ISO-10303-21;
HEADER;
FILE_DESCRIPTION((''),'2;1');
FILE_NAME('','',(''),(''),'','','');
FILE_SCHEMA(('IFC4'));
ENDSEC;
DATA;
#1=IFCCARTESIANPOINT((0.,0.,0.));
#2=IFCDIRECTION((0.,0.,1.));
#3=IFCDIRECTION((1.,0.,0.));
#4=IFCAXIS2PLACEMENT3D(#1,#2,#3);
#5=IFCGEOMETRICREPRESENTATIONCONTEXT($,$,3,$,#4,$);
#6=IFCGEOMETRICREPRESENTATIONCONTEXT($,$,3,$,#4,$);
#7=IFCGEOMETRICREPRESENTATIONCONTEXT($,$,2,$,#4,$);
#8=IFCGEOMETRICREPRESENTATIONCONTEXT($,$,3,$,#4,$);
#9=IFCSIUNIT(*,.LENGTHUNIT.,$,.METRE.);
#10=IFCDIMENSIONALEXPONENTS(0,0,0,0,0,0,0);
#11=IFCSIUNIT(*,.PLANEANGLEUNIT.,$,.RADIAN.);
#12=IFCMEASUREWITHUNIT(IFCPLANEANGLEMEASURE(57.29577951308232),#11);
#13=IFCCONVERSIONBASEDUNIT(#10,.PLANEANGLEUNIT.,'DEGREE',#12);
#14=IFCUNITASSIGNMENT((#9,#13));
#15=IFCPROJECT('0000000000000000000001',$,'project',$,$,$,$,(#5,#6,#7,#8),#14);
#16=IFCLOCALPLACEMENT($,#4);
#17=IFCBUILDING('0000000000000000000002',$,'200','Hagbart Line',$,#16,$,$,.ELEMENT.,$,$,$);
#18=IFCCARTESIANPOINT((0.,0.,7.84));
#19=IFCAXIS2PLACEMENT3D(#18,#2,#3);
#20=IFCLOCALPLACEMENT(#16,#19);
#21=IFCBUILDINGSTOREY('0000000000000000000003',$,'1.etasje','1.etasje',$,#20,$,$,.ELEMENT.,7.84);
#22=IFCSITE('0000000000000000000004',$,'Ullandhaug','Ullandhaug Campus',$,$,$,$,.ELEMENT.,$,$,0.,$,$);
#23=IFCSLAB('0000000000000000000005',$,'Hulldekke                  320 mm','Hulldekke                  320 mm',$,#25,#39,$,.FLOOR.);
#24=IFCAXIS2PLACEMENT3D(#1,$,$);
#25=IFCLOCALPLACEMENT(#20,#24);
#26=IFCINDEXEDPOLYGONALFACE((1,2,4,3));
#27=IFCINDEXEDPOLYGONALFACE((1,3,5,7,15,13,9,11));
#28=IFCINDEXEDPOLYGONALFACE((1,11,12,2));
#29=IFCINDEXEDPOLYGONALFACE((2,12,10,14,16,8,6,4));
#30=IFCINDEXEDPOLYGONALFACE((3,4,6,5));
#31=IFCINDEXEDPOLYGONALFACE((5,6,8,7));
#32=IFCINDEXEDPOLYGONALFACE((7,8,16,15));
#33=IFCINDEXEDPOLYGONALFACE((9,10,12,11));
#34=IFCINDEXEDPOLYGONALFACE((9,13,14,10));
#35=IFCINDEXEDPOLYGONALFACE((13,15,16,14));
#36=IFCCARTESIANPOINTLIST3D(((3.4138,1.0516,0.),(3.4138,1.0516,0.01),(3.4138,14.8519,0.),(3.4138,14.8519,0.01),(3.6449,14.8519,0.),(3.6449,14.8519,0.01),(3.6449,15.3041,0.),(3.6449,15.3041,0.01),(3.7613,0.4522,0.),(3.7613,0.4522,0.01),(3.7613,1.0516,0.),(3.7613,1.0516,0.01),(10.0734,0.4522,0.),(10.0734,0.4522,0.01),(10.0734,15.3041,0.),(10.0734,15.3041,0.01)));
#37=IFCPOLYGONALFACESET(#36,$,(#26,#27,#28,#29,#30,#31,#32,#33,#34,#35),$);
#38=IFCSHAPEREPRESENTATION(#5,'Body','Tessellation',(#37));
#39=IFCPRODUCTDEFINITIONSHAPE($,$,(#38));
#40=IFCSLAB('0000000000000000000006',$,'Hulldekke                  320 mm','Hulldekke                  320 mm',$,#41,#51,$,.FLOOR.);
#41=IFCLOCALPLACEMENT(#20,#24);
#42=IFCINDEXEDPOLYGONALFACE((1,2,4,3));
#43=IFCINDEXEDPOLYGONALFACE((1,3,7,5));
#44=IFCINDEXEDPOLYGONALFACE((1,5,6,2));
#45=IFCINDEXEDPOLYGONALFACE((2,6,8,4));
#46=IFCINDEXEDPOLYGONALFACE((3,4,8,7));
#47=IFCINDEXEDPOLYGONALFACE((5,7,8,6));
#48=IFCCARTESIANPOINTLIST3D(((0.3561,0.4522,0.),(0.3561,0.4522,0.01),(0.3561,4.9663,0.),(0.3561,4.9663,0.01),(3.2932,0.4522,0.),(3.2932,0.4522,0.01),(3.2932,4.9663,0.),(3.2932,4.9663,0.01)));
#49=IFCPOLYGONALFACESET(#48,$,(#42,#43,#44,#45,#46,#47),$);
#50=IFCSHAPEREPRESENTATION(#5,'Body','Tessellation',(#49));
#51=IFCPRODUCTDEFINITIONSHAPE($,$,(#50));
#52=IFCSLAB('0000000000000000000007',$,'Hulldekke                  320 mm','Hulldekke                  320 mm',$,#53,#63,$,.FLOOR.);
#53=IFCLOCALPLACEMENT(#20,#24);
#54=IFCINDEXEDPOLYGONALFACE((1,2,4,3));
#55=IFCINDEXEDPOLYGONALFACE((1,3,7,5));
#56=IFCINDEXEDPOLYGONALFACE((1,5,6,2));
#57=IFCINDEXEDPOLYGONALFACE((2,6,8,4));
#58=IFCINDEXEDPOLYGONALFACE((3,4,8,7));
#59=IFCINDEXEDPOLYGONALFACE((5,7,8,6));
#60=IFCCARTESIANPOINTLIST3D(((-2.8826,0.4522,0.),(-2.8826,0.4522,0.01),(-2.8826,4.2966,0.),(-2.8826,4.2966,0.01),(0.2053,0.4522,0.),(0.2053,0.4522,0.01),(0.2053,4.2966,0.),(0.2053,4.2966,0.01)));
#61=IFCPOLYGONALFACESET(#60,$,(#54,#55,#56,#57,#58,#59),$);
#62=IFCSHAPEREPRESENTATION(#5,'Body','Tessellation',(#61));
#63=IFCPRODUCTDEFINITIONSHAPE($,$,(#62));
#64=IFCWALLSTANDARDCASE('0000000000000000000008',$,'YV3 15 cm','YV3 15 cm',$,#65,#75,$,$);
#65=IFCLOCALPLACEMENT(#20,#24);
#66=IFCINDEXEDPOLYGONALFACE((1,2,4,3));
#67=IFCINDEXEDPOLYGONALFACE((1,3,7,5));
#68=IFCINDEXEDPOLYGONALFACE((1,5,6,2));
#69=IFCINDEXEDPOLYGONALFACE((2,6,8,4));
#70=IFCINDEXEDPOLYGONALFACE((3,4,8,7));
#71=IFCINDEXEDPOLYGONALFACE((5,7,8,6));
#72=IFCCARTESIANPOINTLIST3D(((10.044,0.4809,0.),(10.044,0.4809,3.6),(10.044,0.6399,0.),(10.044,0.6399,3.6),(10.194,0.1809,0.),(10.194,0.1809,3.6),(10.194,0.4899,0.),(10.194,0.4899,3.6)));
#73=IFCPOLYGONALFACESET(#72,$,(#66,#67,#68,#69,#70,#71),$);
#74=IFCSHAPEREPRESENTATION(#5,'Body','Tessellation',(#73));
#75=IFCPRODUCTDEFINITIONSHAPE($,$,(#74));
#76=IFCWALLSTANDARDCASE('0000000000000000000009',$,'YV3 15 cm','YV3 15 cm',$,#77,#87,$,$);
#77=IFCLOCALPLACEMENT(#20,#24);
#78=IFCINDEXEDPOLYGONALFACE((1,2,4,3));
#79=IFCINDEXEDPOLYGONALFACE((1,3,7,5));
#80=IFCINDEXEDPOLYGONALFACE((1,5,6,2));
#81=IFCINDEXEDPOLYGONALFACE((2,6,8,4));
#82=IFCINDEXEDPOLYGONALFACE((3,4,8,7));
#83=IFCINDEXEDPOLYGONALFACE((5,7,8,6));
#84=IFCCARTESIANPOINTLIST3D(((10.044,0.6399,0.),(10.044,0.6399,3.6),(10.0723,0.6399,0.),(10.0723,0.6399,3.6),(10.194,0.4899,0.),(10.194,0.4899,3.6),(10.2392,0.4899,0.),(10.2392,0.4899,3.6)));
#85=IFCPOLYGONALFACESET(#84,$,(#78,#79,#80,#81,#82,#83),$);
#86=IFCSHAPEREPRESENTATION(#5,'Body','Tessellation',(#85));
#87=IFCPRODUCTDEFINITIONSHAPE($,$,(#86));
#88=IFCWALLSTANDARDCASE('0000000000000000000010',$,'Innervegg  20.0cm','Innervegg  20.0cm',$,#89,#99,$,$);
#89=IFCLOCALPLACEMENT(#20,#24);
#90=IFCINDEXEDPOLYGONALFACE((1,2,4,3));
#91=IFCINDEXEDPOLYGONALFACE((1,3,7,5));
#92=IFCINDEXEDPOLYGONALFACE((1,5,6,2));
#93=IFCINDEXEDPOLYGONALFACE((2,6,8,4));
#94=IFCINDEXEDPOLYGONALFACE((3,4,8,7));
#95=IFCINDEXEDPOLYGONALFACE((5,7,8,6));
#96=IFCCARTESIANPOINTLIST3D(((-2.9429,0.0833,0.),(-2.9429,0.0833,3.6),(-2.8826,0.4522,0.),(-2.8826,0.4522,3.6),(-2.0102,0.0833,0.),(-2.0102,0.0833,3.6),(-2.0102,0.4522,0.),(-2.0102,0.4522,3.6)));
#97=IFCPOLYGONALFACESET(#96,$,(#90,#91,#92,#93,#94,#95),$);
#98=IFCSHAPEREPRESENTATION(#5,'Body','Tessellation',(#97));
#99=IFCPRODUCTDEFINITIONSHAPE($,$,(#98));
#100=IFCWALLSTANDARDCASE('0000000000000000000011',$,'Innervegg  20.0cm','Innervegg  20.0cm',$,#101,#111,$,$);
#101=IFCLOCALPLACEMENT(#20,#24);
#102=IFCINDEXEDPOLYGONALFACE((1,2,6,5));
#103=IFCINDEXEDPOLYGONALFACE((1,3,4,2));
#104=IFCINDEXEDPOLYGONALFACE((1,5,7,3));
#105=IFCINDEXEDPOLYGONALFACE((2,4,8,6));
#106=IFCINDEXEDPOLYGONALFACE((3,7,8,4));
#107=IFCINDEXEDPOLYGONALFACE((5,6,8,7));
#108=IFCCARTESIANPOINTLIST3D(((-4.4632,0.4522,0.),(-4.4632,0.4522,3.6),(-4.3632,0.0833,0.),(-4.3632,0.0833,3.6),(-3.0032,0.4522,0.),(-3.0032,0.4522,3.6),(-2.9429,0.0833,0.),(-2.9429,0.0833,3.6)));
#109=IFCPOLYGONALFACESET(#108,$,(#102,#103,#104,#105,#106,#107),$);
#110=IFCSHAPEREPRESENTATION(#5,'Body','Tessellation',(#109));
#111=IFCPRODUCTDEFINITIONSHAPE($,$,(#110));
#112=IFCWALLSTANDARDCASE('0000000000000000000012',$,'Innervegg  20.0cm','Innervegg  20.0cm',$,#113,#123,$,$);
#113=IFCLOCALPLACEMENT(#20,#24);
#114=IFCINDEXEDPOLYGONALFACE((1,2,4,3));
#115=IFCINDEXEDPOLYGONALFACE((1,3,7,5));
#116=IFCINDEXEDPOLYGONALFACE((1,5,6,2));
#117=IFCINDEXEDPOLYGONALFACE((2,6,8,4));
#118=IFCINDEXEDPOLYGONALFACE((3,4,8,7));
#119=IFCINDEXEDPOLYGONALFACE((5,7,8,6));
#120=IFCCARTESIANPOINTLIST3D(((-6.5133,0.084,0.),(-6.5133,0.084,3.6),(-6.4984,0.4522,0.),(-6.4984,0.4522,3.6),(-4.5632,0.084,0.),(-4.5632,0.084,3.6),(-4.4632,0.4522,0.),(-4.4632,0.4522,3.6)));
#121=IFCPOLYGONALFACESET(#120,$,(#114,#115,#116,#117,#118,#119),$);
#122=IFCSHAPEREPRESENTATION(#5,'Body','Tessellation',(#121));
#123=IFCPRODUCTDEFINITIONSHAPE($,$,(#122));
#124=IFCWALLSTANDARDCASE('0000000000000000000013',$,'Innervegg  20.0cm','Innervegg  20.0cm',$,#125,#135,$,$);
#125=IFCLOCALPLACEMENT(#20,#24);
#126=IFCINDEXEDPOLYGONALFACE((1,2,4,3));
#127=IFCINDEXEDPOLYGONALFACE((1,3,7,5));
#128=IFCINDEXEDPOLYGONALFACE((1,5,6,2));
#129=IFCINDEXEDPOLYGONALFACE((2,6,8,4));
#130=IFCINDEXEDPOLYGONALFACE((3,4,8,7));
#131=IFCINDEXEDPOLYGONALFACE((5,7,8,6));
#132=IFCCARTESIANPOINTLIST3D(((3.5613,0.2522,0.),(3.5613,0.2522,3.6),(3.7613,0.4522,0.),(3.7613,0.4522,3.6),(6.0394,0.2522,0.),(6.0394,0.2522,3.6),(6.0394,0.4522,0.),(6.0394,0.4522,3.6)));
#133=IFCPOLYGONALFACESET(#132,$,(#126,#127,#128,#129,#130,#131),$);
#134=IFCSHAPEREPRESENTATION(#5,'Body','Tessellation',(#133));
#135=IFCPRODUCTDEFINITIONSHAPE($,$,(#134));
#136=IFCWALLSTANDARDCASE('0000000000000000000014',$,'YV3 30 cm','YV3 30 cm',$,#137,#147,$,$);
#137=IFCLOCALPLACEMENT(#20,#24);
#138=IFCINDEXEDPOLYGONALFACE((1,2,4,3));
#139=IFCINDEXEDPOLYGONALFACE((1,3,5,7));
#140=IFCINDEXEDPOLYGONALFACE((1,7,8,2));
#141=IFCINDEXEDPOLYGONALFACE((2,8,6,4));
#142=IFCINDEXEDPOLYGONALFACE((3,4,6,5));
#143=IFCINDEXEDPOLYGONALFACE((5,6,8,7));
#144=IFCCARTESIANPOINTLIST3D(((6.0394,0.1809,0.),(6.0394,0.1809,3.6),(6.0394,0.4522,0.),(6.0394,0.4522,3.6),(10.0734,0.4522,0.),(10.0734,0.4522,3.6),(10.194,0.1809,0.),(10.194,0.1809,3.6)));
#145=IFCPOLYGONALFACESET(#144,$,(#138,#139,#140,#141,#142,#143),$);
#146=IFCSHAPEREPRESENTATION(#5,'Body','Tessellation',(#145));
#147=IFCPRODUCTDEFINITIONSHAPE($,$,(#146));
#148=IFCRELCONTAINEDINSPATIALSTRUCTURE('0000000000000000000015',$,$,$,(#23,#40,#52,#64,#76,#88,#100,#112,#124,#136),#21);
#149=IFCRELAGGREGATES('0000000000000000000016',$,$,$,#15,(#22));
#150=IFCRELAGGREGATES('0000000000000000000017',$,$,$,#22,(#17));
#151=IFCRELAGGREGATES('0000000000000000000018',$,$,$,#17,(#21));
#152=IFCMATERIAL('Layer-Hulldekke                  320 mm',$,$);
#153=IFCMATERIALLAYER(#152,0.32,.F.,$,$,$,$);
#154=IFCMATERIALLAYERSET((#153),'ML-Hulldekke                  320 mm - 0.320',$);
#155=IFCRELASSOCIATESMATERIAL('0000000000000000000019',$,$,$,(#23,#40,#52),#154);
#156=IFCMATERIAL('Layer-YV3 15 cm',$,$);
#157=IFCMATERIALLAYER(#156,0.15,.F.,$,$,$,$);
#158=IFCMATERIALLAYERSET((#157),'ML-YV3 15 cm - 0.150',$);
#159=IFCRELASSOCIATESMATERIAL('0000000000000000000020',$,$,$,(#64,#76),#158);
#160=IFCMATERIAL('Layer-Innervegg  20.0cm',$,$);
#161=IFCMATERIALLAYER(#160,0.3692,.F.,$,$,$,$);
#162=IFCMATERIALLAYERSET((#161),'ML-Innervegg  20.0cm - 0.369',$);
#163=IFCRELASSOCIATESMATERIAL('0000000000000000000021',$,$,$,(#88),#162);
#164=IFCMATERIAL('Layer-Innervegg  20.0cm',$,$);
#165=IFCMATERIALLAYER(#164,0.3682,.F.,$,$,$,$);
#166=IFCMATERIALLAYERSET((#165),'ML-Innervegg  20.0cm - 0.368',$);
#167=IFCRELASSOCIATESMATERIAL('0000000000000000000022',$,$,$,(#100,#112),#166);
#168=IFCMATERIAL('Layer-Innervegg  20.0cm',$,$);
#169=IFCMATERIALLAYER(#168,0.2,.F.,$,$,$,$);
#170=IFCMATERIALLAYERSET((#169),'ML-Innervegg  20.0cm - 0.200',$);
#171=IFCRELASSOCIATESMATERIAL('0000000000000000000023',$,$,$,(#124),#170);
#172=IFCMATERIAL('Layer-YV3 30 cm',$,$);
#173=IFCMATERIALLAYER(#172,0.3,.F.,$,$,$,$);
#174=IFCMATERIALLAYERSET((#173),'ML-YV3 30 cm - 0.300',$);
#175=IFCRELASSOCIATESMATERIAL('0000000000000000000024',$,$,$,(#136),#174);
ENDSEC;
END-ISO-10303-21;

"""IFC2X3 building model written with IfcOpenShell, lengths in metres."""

from ifc_helpers import new_model, entity, si_unit, converted_unit, frame, origin_with_axes, place, context, project, spatial, polyline, outline, extrude, material, layer, layer_set, layer_usage, element, save


model = new_model("IFC2X3")

# Units and contexts
context_of_model_1 = context(None, 3, world=origin_with_axes())
context_of_model_2 = context(None, 3, world=origin_with_axes())
context_of_model_3 = context(None, 2, world=origin_with_axes())
context_of_model_4 = context(None, 3, world=origin_with_axes())
ifc_project = project(units=[si_unit("LENGTHUNIT", "METRE"), converted_unit("PLANEANGLEUNIT", "DEGREE", entity("IfcPlaneAngleMeasure", 57.29577951308232), si_unit("PLANEANGLEUNIT", "RADIAN"), dimensions=[0, 0, 0, 0, 0, 0, 0])], contexts=[context_of_model_1, context_of_model_2, context_of_model_3, context_of_model_4])

# Site, building, storey
site = spatial("IfcSite", under=ifc_project, Name="Ullandhaug", Description="Ullandhaug Campus", CompositionType="ELEMENT", RefElevation=0.0)
building_placement = place(None, origin_with_axes())
building = spatial("IfcBuilding", under=site, at=building_placement, Name="200", Description="Hagbart Line", CompositionType="ELEMENT")
storey_placement = place(building_placement, frame((0.0, 0.0, 7.84), z_axis=(0.0, 0.0, 1.0), x_axis=(1.0, 0.0, 0.0)))
storey = spatial("IfcBuildingStorey", under=building, at=storey_placement, Name="1.etasje", Description="1.etasje", CompositionType="ELEMENT", Elevation=7.84)

# Slabs
ifc_material_1 = material(Name="Layer-Hulldekke                  320 mm")
ifc_layer_1 = layer(ifc_material_1, 0.32, ventilated=False)
ifc_layer_set_1 = layer_set([ifc_layer_1], Name="ML-Hulldekke                  320 mm - 0.320")
ifc_layer_usage_1 = layer_usage(ifc_layer_set_1, "AXIS2", "POSITIVE", 0.0)
slab_1_placement = place(storey_placement, frame((3.7613, 0.4522, 0.0), z_axis=(0.0, 0.0, 1.0), x_axis=(1.0, 0.0, 0.0)))
element("IfcSlab", 1, at=slab_1_placement, inside=storey, material=ifc_layer_usage_1, Name="Hulldekke                  320 mm", Description="Hulldekke                  320 mm", PredefinedType="FLOOR", context=context_of_model_1, shape_type="SweptSolid", body=[
    extrude(outline(polyline([(0.0, 0.0), (6.3121, 0.0), (6.3121, 14.8519), (-0.1164, 14.8519), (-0.1164, 14.3996), (-0.3475, 14.3996), (-0.3475, 0.5994), (0.0, 0.5994), (0.0, 0.0)])), origin_with_axes(), (0.0, 0.0, 1.0), 0.01),
])
slab_2_placement = place(storey_placement, frame((0.3561, 0.4522, 0.0), z_axis=(0.0, 0.0, 1.0), x_axis=(1.0, 0.0, 0.0)))
element("IfcSlab", 2, at=slab_2_placement, inside=storey, material=ifc_layer_usage_1, Name="Hulldekke                  320 mm", Description="Hulldekke                  320 mm", PredefinedType="FLOOR", context=context_of_model_1, shape_type="SweptSolid", body=[
    extrude(outline(polyline([(0.0, 0.0), (2.9371, 0.0), (2.9371, 4.5141), (0.0, 4.5141), (0.0, 0.0)])), origin_with_axes(), (0.0, 0.0, 1.0), 0.01),
])
slab_3_placement = place(storey_placement, frame((-2.8826, 0.4522, 0.0), z_axis=(0.0, 0.0, 1.0), x_axis=(1.0, 0.0, 0.0)))
element("IfcSlab", 3, at=slab_3_placement, inside=storey, material=ifc_layer_usage_1, Name="Hulldekke                  320 mm", Description="Hulldekke                  320 mm", PredefinedType="FLOOR", context=context_of_model_1, shape_type="SweptSolid", body=[
    extrude(outline(polyline([(0.0, 0.0), (3.0879, 0.0), (3.0879, 3.8444), (0.0, 3.8444), (0.0, 0.0)])), origin_with_axes(), (0.0, 0.0, 1.0), 0.01),
])

# Walls
ifc_material_2 = material(Name="Layer-YV3 15 cm")
ifc_layer_2 = layer(ifc_material_2, 0.15, ventilated=False)
ifc_layer_set_2 = layer_set([ifc_layer_2], Name="ML-YV3 15 cm - 0.150")
ifc_layer_usage_2 = layer_usage(ifc_layer_set_2, "AXIS2", "POSITIVE", 0.0)
wall_1_placement = place(storey_placement, frame((10.194, 0.1809, 0.0), z_axis=(0.0, 0.0, 1.0), x_axis=(0.0, 1.0, 0.0)))
element("IfcWallStandardCase", 4, at=wall_1_placement, inside=storey, material=ifc_layer_usage_2, Name="YV3 15 cm", Description="YV3 15 cm", context=context_of_model_1, shape_type="SweptSolid", body=[
    extrude(outline(polyline([(0.0, 0.0), (0.309, 0.0), (0.459, 0.15), (0.3, 0.15), (0.0, 0.0)])), frame((0.0, 0.0, 0.0), z_axis=(0.0, 0.0, 1.0), x_axis=(1.0, 0.0, 0.0)), (0.0, 0.0, 1.0), 3.6),
])
wall_2_placement = place(storey_placement, frame((10.194, 0.4899, 0.0), z_axis=(0.0, 0.0, 1.0), x_axis=(1.0, 0.0, 0.0)))
element("IfcWallStandardCase", 5, at=wall_2_placement, inside=storey, material=ifc_layer_usage_2, Name="YV3 15 cm", Description="YV3 15 cm", context=context_of_model_1, shape_type="SweptSolid", body=[
    extrude(outline(polyline([(0.0, 0.0), (0.0452, 0.0), (-0.1218, 0.15), (-0.15, 0.15), (0.0, 0.0)])), origin_with_axes(), (0.0, 0.0, 1.0), 3.6),
])
ifc_material_3 = material(Name="Layer-Innervegg  20.0cm")
ifc_layer_3 = layer(ifc_material_3, 0.3692, ventilated=False)
ifc_layer_set_3 = layer_set([ifc_layer_3], Name="ML-Innervegg  20.0cm - 0.369")
ifc_layer_usage_3 = layer_usage(ifc_layer_set_3, "AXIS2", "POSITIVE", 0.0)
wall_3_placement = place(storey_placement, frame((-2.0102, 0.4522, 0.0), z_axis=(0.0, 0.0, 1.0), x_axis=(-1.0, 0.0, 0.0)))
element("IfcWallStandardCase", 6, at=wall_3_placement, inside=storey, material=ifc_layer_usage_3, Name="Innervegg  20.0cm", Description="Innervegg  20.0cm", context=context_of_model_1, shape_type="SweptSolid", body=[
    extrude(outline(polyline([(0.0, 0.0), (0.8724, 0.0), (0.9327, 0.3689), (0.0, 0.3689), (0.0, 0.0)])), frame((0.0, 0.0, 0.0), z_axis=(0.0, 0.0, 1.0), x_axis=(1.0, 0.0, 0.0)), (0.0, 0.0, 1.0), 3.6),
])
ifc_material_4 = material(Name="Layer-Innervegg  20.0cm")
ifc_layer_4 = layer(ifc_material_4, 0.3682, ventilated=False)
ifc_layer_set_4 = layer_set([ifc_layer_4], Name="ML-Innervegg  20.0cm - 0.368")
ifc_layer_usage_4 = layer_usage(ifc_layer_set_4, "AXIS2", "POSITIVE", 0.0)
wall_4_placement = place(storey_placement, frame((-3.0032, 0.4522, 0.0), z_axis=(0.0, 0.0, 1.0), x_axis=(-1.0, 0.0, 0.0)))
element("IfcWallStandardCase", 7, at=wall_4_placement, inside=storey, material=ifc_layer_usage_4, Name="Innervegg  20.0cm", Description="Innervegg  20.0cm", context=context_of_model_1, shape_type="SweptSolid", body=[
    extrude(outline(polyline([(0.0, 0.0), (1.46, 0.0), (1.36, 0.3689), (-0.0603, 0.3689), (0.0, 0.0)])), frame((0.0, 0.0, 0.0), z_axis=(0.0, 0.0, 1.0), x_axis=(1.0, 0.0, 0.0)), (0.0, 0.0, 1.0), 3.6),
])
wall_5_placement = place(storey_placement, frame((-4.4632, 0.4522, 0.0), z_axis=(0.0, 0.0, 1.0), x_axis=(-1.0, 0.0, 0.0)))
element("IfcWallStandardCase", 8, at=wall_5_placement, inside=storey, material=ifc_layer_usage_4, Name="Innervegg  20.0cm", Description="Innervegg  20.0cm", context=context_of_model_1, shape_type="SweptSolid", body=[
    extrude(outline(polyline([(0.0, 0.0), (2.0352, 0.0), (2.0501, 0.3682), (0.1, 0.3682), (0.0, 0.0)])), frame((0.0, 0.0, 0.0), z_axis=(0.0, 0.0, 1.0), x_axis=(1.0, 0.0, 0.0)), (0.0, 0.0, 1.0), 3.6),
])
ifc_material_5 = material(Name="Layer-Innervegg  20.0cm")
ifc_layer_5 = layer(ifc_material_5, 0.2, ventilated=False)
ifc_layer_set_5 = layer_set([ifc_layer_5], Name="ML-Innervegg  20.0cm - 0.200")
ifc_layer_usage_5 = layer_usage(ifc_layer_set_5, "AXIS2", "POSITIVE", 0.0)
wall_6_placement = place(storey_placement, frame((3.5613, 0.2522, 0.0), z_axis=(0.0, 0.0, 1.0), x_axis=(1.0, 0.0, 0.0)))
element("IfcWallStandardCase", 9, at=wall_6_placement, inside=storey, material=ifc_layer_usage_5, Name="Innervegg  20.0cm", Description="Innervegg  20.0cm", context=context_of_model_1, shape_type="SweptSolid", body=[
    extrude(outline(polyline([(0.0, 0.0), (2.4781, 0.0), (2.4781, 0.2), (0.2, 0.2), (0.0, 0.0)])), frame((0.0, 0.0, 0.0), z_axis=(0.0, 0.0, 1.0), x_axis=(1.0, 0.0, 0.0)), (0.0, 0.0, 1.0), 3.6),
])
ifc_material_6 = material(Name="Layer-YV3 30 cm")
ifc_layer_6 = layer(ifc_material_6, 0.3, ventilated=False)
ifc_layer_set_6 = layer_set([ifc_layer_6], Name="ML-YV3 30 cm - 0.300")
ifc_layer_usage_6 = layer_usage(ifc_layer_set_6, "AXIS2", "POSITIVE", 0.0)
wall_7_placement = place(storey_placement, frame((6.0394, 0.1809, 0.0), z_axis=(0.0, 0.0, 1.0), x_axis=(1.0, 0.0, 0.0)))
element("IfcWallStandardCase", 10, at=wall_7_placement, inside=storey, material=ifc_layer_usage_6, Name="YV3 30 cm", Description="YV3 30 cm", context=context_of_model_1, shape_type="SweptSolid", body=[
    extrude(outline(polyline([(0.0, 0.0), (4.1546, 0.0), (4.034, 0.2714), (0.0, 0.2714), (0.0, 0.0)])), frame((0.0, 0.0, 0.0), z_axis=(0.0, 0.0, 1.0), x_axis=(1.0, 0.0, 0.0)), (0.0, 0.0, 1.0), 3.6),
])

save(model, "model.ifc")
